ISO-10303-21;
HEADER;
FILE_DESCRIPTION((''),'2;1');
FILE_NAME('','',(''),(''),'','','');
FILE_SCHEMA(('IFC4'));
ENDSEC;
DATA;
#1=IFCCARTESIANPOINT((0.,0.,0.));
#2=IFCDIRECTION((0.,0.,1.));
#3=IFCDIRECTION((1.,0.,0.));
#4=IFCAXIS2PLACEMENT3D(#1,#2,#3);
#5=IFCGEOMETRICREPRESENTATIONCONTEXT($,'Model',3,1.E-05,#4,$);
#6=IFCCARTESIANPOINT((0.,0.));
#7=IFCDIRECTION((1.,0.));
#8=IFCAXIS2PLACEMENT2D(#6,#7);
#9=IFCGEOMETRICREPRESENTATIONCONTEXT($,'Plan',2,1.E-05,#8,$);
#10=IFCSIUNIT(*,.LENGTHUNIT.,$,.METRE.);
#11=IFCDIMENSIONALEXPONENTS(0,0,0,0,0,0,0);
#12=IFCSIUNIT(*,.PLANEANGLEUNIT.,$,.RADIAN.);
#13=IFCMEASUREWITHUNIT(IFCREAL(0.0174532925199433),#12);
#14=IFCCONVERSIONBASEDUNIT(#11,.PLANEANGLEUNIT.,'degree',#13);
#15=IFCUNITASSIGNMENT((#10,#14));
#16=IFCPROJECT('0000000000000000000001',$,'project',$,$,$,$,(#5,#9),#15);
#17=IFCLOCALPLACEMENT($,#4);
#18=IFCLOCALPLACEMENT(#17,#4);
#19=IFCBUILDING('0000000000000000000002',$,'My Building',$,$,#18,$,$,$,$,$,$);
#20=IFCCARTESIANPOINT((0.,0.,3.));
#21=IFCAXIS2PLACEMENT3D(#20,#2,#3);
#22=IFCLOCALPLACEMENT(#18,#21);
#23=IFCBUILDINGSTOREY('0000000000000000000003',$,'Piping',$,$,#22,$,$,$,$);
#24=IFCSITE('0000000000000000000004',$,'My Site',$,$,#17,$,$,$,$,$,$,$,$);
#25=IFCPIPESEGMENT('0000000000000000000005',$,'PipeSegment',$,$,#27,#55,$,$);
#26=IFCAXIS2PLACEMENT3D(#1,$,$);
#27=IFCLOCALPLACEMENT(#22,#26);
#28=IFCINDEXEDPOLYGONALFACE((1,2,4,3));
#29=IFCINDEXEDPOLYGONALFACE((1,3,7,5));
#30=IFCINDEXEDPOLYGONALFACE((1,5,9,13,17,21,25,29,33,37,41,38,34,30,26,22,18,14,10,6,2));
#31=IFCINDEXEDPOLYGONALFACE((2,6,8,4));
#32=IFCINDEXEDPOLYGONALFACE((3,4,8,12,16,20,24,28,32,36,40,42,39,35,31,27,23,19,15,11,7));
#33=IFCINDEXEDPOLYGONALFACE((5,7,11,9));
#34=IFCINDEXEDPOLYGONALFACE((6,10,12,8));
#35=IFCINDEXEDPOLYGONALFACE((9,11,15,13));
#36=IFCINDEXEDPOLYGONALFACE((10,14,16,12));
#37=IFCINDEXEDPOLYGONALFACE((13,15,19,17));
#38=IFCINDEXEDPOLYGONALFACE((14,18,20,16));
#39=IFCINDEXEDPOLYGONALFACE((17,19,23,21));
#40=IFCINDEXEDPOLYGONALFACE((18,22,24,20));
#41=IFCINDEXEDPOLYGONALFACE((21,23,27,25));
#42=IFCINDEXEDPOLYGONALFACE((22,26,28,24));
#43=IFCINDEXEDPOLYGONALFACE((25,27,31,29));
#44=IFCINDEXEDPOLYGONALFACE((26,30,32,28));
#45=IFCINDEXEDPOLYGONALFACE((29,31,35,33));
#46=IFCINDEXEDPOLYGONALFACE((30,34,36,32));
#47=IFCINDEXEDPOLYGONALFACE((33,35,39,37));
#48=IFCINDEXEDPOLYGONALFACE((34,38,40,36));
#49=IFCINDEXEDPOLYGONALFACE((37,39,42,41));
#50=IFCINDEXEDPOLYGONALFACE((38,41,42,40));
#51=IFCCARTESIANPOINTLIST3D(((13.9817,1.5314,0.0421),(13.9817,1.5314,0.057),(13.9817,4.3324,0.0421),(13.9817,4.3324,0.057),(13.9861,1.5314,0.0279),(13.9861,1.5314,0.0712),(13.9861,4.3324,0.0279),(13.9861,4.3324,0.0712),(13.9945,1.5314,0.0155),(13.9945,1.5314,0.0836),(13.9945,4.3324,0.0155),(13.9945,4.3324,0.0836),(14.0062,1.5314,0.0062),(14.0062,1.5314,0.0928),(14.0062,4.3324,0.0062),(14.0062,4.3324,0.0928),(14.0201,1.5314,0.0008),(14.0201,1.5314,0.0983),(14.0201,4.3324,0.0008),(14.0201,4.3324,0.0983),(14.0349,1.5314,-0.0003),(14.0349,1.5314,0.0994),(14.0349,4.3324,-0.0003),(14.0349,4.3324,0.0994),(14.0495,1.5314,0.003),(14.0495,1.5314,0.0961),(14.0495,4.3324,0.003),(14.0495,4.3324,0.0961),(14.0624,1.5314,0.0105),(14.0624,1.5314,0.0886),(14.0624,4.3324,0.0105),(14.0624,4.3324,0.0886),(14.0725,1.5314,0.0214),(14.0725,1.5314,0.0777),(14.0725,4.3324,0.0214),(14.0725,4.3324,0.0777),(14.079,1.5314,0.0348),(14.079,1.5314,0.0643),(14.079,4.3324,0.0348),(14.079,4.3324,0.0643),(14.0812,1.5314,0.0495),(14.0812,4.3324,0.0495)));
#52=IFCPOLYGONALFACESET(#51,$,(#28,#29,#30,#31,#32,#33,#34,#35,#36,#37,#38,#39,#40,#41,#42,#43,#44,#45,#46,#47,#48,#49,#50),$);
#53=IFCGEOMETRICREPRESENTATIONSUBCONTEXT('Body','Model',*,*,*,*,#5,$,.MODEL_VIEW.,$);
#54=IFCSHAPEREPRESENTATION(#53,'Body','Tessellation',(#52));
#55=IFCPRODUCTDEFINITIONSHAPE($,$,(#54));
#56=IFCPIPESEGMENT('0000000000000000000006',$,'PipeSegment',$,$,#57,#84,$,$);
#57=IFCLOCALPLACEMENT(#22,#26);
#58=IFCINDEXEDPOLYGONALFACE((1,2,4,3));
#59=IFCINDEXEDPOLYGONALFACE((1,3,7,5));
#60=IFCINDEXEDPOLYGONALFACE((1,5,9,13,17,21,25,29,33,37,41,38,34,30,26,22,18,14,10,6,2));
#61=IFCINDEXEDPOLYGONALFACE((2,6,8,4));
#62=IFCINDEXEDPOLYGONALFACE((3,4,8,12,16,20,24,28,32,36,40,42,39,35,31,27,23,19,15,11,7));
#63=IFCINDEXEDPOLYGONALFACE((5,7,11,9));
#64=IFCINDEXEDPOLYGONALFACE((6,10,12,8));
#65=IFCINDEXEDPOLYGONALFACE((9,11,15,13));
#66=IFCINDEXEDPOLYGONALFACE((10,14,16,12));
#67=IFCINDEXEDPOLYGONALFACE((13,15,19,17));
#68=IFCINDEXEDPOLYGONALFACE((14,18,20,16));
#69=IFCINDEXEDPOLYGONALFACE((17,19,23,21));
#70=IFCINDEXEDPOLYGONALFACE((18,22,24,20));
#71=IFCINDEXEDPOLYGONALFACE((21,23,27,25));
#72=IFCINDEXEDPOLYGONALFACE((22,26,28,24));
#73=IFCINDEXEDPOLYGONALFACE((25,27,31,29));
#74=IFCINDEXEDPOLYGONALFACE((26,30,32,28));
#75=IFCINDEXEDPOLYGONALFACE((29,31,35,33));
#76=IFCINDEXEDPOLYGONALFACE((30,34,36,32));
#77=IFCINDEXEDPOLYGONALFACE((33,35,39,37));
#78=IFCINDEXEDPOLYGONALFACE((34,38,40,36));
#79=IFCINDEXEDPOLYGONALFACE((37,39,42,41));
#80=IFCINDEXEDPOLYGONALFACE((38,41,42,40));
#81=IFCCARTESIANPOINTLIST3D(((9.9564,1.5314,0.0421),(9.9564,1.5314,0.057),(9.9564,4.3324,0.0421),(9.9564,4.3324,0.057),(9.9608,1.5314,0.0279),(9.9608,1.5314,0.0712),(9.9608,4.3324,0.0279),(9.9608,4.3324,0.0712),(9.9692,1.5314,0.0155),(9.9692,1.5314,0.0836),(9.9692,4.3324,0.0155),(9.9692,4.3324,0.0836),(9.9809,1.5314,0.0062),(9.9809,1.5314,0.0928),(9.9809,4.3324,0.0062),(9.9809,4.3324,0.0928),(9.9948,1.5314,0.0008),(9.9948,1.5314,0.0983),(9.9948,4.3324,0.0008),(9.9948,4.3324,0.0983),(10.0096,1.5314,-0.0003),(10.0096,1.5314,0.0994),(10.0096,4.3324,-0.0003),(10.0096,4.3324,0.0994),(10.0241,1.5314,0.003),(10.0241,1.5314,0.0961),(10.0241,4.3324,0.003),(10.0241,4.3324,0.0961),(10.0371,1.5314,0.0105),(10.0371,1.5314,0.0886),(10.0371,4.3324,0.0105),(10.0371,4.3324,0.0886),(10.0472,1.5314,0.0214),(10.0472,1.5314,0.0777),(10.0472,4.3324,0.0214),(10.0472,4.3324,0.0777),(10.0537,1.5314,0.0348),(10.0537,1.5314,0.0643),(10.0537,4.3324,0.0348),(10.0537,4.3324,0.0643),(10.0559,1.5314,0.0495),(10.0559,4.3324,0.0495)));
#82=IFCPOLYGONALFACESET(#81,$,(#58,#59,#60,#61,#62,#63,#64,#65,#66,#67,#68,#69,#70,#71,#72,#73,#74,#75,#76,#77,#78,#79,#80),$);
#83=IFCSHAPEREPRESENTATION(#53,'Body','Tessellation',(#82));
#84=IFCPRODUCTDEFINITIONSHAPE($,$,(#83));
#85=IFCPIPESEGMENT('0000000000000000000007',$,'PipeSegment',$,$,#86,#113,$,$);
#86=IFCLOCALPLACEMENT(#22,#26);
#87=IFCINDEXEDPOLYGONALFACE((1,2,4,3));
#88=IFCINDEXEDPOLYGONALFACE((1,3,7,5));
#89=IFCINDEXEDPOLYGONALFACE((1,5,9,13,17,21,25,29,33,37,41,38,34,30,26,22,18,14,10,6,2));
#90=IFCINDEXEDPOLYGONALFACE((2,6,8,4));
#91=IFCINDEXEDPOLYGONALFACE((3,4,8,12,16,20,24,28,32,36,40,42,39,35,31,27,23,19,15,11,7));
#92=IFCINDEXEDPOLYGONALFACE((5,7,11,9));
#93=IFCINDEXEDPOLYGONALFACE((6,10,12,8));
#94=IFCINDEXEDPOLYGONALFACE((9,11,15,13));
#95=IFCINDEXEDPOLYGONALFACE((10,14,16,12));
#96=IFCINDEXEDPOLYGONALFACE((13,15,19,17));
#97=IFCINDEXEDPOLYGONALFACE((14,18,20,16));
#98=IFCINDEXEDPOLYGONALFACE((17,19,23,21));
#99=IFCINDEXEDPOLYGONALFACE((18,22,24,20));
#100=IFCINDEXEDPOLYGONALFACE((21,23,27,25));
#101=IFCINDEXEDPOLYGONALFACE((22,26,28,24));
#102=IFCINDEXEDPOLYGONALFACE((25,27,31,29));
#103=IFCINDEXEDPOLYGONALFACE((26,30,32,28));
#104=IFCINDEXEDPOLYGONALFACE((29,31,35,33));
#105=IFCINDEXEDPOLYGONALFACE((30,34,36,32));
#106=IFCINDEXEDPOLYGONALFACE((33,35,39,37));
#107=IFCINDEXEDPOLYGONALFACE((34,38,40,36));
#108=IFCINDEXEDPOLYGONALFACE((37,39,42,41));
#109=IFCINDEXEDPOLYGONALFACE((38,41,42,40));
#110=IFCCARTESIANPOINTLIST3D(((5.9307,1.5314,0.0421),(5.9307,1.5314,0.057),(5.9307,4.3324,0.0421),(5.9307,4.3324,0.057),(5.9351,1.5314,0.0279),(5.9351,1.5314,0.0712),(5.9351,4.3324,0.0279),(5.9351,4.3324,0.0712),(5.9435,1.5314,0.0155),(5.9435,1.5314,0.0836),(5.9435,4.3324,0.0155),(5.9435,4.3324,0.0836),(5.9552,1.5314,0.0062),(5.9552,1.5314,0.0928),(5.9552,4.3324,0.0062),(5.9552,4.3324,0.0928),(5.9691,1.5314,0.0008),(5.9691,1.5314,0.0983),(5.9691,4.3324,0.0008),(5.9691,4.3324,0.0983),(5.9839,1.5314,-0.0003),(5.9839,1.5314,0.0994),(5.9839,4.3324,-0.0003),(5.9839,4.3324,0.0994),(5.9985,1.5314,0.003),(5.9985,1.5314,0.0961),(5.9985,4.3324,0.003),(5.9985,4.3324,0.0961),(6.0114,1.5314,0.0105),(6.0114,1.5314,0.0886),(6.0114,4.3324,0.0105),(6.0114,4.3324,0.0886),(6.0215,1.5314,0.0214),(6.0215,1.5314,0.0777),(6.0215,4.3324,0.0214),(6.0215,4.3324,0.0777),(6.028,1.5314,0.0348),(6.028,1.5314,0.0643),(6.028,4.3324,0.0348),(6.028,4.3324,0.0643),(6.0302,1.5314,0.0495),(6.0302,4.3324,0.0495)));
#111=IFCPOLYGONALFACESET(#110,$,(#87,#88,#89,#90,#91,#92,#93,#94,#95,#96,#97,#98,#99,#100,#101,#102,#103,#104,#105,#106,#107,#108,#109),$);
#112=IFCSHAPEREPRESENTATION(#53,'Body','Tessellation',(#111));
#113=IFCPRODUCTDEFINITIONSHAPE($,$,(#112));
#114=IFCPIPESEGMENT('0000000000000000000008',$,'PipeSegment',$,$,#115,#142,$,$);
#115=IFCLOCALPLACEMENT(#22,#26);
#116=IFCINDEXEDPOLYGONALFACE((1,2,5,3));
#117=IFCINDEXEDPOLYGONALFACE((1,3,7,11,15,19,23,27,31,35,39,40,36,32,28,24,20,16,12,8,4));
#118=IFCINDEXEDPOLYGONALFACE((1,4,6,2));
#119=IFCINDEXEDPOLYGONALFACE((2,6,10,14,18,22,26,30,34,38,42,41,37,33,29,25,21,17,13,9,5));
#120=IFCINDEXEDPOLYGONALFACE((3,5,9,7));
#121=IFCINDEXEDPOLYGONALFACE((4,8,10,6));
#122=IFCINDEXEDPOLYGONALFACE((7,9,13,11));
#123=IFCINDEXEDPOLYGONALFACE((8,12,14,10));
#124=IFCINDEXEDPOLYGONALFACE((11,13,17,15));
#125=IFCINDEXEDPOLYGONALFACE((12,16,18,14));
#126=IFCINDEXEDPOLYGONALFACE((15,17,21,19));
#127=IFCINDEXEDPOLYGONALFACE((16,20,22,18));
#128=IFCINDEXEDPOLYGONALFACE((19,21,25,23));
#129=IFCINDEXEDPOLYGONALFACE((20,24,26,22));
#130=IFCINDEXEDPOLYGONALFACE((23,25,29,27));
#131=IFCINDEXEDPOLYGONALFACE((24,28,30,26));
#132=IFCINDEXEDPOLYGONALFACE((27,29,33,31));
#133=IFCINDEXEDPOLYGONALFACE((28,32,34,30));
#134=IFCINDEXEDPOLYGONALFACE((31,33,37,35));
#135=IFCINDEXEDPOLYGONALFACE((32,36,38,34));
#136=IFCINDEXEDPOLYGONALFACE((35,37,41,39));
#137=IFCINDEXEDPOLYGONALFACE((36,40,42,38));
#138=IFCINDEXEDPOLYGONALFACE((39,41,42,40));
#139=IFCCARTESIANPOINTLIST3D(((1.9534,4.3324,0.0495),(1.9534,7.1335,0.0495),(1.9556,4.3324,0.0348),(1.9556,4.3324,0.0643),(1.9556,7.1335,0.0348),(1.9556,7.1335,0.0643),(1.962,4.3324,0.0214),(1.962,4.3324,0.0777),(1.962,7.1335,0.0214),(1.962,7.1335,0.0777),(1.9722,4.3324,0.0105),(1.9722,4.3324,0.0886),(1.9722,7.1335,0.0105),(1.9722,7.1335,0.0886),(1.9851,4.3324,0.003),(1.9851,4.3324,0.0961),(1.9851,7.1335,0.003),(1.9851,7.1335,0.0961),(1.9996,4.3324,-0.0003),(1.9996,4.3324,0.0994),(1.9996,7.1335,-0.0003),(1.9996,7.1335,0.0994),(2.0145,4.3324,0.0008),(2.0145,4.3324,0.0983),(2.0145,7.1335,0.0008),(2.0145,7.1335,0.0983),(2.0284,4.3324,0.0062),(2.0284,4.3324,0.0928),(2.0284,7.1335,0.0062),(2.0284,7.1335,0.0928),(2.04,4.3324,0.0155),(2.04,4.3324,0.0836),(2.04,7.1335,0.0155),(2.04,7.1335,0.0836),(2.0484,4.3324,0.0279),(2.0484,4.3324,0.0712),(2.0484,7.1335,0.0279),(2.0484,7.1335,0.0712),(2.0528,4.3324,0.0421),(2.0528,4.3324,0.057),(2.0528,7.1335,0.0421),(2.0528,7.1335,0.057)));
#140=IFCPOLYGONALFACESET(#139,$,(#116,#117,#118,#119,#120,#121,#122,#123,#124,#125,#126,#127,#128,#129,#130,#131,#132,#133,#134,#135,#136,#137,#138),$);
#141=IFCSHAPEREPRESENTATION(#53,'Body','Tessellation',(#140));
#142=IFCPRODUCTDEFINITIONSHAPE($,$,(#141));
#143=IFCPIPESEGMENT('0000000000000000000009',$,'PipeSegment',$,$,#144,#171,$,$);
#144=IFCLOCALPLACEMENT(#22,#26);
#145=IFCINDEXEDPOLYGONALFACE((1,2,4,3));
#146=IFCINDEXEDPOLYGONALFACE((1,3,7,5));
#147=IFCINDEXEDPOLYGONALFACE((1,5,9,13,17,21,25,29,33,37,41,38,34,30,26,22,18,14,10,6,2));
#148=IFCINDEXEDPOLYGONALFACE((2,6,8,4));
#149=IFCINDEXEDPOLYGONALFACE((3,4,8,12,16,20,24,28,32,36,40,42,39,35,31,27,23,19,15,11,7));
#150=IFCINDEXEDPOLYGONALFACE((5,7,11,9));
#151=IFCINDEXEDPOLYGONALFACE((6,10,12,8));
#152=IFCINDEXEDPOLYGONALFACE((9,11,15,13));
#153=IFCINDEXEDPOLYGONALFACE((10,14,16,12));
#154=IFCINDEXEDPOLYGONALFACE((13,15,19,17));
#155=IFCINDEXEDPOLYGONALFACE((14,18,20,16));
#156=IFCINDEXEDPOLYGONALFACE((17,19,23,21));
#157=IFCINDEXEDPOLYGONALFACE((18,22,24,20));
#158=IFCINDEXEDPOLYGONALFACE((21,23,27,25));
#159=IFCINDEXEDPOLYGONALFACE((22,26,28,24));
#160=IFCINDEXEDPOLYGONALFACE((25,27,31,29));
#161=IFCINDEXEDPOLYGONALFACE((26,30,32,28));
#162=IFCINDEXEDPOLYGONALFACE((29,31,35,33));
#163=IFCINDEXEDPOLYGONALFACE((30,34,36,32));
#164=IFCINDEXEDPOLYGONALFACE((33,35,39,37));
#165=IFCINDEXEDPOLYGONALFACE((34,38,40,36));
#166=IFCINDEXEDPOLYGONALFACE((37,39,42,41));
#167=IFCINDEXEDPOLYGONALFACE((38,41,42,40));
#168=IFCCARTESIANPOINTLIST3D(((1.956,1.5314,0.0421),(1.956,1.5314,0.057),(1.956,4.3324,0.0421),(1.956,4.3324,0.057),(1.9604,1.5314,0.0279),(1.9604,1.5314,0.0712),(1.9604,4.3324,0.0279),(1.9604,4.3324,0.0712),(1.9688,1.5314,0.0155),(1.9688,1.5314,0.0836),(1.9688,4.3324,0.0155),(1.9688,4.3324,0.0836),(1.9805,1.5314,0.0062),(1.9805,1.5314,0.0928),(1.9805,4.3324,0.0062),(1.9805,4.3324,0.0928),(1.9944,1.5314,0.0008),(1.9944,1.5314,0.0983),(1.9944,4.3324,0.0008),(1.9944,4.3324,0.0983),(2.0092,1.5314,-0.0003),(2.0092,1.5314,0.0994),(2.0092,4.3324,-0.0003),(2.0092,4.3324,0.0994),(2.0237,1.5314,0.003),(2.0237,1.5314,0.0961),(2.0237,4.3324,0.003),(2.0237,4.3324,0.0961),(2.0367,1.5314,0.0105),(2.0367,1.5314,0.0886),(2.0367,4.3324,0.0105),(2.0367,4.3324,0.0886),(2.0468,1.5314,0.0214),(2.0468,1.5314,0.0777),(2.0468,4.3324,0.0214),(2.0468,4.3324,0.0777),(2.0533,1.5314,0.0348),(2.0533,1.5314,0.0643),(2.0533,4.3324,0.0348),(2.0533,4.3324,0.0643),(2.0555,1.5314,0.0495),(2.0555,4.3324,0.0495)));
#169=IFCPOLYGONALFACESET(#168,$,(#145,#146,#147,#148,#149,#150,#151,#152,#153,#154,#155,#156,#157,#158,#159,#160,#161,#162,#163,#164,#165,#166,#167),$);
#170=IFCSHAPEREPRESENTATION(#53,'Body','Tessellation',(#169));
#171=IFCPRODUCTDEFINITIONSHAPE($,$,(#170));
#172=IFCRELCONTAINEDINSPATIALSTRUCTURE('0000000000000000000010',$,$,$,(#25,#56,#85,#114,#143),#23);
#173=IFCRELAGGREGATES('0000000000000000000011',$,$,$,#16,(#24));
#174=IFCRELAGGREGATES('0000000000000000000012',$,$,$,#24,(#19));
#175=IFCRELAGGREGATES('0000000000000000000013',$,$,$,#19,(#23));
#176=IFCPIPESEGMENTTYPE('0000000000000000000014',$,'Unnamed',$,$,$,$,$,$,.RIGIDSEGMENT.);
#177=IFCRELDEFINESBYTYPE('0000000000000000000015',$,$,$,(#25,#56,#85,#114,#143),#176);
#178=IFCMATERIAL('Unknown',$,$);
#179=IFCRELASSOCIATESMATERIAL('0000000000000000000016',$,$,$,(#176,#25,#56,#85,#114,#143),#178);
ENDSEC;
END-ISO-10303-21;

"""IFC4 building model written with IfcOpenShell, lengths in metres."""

from ifc_helpers import new_model, entity, si_unit, converted_unit, frame, origin_with_axes, origin_2d_with_axis, place, context, subcontext, project, spatial, circle, extrude, material, material_profile, profile_set, profile_usage, type_object, element, save


model = new_model("IFC4")

# Units and contexts
model_context = context("Model", 3, precision=1e-05, world=origin_with_axes())
plan_context = context("Plan", 2, precision=1e-05, world=origin_2d_with_axis())
body_context = subcontext(model_context, "Body", "Model", "MODEL_VIEW")
ifc_project = project(units=[si_unit("LENGTHUNIT", "METRE"), converted_unit("PLANEANGLEUNIT", "degree", entity("IfcReal", 0.0174532925199433), si_unit("PLANEANGLEUNIT", "RADIAN"), dimensions=[0, 0, 0, 0, 0, 0, 0])], contexts=[model_context, plan_context])

# Site, building, storey
site_placement = place(None, origin_with_axes())
site = spatial("IfcSite", under=ifc_project, at=site_placement, Name="My Site")
building_placement = place(site_placement, origin_with_axes())
building = spatial("IfcBuilding", under=site, at=building_placement, Name="My Building")
storey_placement = place(building_placement, frame((0.0, 0.0, 3.0), z_axis=(0.0, 0.0, 1.0), x_axis=(1.0, 0.0, 0.0)))
storey = spatial("IfcBuildingStorey", under=building, at=storey_placement, Name="Piping")

# Pipe segments
ifc_material = material(Name="Unknown")
ifc_material_profile = material_profile(ifc_material, circle(Radius=0.05))
ifc_profile_set = profile_set([ifc_material_profile])
pipe_segment_type = type_object("IfcPipeSegmentType", Name="Unnamed", PredefinedType="RIGIDSEGMENT", material=ifc_profile_set)
ifc_profile_usage_1 = profile_usage(ifc_profile_set, cardinal=5)
pipe_segment_1_placement = place(storey_placement, frame((14.0312, 4.3324, 0.0495), z_axis=(0.0, -1.0, 0.0), x_axis=(1.0, 0.0, 0.0)))
element("IfcPipeSegment", 1, at=pipe_segment_1_placement, inside=storey, type_object=pipe_segment_type, material=ifc_profile_usage_1, Name="PipeSegment", context=body_context, shape_type="SweptSolid", body=[
    extrude(circle(Radius=0.05), origin_with_axes(), (0.0, 0.0, 1.0), 2.8011),
])
ifc_profile_usage_2 = profile_usage(ifc_profile_set, cardinal=5)
pipe_segment_2_placement = place(storey_placement, frame((10.0059, 4.3324, 0.0495), z_axis=(0.0, -1.0, 0.0), x_axis=(1.0, 0.0, 0.0)))
element("IfcPipeSegment", 2, at=pipe_segment_2_placement, inside=storey, type_object=pipe_segment_type, material=ifc_profile_usage_2, Name="PipeSegment", context=body_context, shape_type="SweptSolid", body=[
    extrude(circle(Radius=0.05), origin_with_axes(), (0.0, 0.0, 1.0), 2.8011),
])
ifc_profile_usage_3 = profile_usage(ifc_profile_set, cardinal=5)
pipe_segment_3_placement = place(storey_placement, frame((5.9802, 4.3324, 0.0495), z_axis=(0.0, -1.0, 0.0), x_axis=(1.0, 0.0, 0.0)))
element("IfcPipeSegment", 3, at=pipe_segment_3_placement, inside=storey, type_object=pipe_segment_type, material=ifc_profile_usage_3, Name="PipeSegment", context=body_context, shape_type="SweptSolid", body=[
    extrude(circle(Radius=0.05), origin_with_axes(), (0.0, 0.0, 1.0), 2.8011),
])
ifc_profile_usage_4 = profile_usage(ifc_profile_set, cardinal=5)
pipe_segment_4_placement = place(storey_placement, frame((2.0034, 4.3324, 0.0495), z_axis=(0.0, 1.0, 0.0), x_axis=(-1.0, 0.0, 0.0)))
element("IfcPipeSegment", 4, at=pipe_segment_4_placement, inside=storey, type_object=pipe_segment_type, material=ifc_profile_usage_4, Name="PipeSegment", context=body_context, shape_type="SweptSolid", body=[
    extrude(circle(Radius=0.05), origin_with_axes(), (0.0, 0.0, 1.0), 2.8011),
])
ifc_profile_usage_5 = profile_usage(ifc_profile_set, cardinal=5)
pipe_segment_5_placement = place(storey_placement, frame((2.0055, 4.3324, 0.0495), z_axis=(0.0, -1.0, 0.0), x_axis=(1.0, 0.0, 0.0)))
element("IfcPipeSegment", 5, at=pipe_segment_5_placement, inside=storey, type_object=pipe_segment_type, material=ifc_profile_usage_5, Name="PipeSegment", context=body_context, shape_type="SweptSolid", body=[
    extrude(circle(Radius=0.05), origin_with_axes(), (0.0, 0.0, 1.0), 2.8011),
])

save(model, "model.ifc")
